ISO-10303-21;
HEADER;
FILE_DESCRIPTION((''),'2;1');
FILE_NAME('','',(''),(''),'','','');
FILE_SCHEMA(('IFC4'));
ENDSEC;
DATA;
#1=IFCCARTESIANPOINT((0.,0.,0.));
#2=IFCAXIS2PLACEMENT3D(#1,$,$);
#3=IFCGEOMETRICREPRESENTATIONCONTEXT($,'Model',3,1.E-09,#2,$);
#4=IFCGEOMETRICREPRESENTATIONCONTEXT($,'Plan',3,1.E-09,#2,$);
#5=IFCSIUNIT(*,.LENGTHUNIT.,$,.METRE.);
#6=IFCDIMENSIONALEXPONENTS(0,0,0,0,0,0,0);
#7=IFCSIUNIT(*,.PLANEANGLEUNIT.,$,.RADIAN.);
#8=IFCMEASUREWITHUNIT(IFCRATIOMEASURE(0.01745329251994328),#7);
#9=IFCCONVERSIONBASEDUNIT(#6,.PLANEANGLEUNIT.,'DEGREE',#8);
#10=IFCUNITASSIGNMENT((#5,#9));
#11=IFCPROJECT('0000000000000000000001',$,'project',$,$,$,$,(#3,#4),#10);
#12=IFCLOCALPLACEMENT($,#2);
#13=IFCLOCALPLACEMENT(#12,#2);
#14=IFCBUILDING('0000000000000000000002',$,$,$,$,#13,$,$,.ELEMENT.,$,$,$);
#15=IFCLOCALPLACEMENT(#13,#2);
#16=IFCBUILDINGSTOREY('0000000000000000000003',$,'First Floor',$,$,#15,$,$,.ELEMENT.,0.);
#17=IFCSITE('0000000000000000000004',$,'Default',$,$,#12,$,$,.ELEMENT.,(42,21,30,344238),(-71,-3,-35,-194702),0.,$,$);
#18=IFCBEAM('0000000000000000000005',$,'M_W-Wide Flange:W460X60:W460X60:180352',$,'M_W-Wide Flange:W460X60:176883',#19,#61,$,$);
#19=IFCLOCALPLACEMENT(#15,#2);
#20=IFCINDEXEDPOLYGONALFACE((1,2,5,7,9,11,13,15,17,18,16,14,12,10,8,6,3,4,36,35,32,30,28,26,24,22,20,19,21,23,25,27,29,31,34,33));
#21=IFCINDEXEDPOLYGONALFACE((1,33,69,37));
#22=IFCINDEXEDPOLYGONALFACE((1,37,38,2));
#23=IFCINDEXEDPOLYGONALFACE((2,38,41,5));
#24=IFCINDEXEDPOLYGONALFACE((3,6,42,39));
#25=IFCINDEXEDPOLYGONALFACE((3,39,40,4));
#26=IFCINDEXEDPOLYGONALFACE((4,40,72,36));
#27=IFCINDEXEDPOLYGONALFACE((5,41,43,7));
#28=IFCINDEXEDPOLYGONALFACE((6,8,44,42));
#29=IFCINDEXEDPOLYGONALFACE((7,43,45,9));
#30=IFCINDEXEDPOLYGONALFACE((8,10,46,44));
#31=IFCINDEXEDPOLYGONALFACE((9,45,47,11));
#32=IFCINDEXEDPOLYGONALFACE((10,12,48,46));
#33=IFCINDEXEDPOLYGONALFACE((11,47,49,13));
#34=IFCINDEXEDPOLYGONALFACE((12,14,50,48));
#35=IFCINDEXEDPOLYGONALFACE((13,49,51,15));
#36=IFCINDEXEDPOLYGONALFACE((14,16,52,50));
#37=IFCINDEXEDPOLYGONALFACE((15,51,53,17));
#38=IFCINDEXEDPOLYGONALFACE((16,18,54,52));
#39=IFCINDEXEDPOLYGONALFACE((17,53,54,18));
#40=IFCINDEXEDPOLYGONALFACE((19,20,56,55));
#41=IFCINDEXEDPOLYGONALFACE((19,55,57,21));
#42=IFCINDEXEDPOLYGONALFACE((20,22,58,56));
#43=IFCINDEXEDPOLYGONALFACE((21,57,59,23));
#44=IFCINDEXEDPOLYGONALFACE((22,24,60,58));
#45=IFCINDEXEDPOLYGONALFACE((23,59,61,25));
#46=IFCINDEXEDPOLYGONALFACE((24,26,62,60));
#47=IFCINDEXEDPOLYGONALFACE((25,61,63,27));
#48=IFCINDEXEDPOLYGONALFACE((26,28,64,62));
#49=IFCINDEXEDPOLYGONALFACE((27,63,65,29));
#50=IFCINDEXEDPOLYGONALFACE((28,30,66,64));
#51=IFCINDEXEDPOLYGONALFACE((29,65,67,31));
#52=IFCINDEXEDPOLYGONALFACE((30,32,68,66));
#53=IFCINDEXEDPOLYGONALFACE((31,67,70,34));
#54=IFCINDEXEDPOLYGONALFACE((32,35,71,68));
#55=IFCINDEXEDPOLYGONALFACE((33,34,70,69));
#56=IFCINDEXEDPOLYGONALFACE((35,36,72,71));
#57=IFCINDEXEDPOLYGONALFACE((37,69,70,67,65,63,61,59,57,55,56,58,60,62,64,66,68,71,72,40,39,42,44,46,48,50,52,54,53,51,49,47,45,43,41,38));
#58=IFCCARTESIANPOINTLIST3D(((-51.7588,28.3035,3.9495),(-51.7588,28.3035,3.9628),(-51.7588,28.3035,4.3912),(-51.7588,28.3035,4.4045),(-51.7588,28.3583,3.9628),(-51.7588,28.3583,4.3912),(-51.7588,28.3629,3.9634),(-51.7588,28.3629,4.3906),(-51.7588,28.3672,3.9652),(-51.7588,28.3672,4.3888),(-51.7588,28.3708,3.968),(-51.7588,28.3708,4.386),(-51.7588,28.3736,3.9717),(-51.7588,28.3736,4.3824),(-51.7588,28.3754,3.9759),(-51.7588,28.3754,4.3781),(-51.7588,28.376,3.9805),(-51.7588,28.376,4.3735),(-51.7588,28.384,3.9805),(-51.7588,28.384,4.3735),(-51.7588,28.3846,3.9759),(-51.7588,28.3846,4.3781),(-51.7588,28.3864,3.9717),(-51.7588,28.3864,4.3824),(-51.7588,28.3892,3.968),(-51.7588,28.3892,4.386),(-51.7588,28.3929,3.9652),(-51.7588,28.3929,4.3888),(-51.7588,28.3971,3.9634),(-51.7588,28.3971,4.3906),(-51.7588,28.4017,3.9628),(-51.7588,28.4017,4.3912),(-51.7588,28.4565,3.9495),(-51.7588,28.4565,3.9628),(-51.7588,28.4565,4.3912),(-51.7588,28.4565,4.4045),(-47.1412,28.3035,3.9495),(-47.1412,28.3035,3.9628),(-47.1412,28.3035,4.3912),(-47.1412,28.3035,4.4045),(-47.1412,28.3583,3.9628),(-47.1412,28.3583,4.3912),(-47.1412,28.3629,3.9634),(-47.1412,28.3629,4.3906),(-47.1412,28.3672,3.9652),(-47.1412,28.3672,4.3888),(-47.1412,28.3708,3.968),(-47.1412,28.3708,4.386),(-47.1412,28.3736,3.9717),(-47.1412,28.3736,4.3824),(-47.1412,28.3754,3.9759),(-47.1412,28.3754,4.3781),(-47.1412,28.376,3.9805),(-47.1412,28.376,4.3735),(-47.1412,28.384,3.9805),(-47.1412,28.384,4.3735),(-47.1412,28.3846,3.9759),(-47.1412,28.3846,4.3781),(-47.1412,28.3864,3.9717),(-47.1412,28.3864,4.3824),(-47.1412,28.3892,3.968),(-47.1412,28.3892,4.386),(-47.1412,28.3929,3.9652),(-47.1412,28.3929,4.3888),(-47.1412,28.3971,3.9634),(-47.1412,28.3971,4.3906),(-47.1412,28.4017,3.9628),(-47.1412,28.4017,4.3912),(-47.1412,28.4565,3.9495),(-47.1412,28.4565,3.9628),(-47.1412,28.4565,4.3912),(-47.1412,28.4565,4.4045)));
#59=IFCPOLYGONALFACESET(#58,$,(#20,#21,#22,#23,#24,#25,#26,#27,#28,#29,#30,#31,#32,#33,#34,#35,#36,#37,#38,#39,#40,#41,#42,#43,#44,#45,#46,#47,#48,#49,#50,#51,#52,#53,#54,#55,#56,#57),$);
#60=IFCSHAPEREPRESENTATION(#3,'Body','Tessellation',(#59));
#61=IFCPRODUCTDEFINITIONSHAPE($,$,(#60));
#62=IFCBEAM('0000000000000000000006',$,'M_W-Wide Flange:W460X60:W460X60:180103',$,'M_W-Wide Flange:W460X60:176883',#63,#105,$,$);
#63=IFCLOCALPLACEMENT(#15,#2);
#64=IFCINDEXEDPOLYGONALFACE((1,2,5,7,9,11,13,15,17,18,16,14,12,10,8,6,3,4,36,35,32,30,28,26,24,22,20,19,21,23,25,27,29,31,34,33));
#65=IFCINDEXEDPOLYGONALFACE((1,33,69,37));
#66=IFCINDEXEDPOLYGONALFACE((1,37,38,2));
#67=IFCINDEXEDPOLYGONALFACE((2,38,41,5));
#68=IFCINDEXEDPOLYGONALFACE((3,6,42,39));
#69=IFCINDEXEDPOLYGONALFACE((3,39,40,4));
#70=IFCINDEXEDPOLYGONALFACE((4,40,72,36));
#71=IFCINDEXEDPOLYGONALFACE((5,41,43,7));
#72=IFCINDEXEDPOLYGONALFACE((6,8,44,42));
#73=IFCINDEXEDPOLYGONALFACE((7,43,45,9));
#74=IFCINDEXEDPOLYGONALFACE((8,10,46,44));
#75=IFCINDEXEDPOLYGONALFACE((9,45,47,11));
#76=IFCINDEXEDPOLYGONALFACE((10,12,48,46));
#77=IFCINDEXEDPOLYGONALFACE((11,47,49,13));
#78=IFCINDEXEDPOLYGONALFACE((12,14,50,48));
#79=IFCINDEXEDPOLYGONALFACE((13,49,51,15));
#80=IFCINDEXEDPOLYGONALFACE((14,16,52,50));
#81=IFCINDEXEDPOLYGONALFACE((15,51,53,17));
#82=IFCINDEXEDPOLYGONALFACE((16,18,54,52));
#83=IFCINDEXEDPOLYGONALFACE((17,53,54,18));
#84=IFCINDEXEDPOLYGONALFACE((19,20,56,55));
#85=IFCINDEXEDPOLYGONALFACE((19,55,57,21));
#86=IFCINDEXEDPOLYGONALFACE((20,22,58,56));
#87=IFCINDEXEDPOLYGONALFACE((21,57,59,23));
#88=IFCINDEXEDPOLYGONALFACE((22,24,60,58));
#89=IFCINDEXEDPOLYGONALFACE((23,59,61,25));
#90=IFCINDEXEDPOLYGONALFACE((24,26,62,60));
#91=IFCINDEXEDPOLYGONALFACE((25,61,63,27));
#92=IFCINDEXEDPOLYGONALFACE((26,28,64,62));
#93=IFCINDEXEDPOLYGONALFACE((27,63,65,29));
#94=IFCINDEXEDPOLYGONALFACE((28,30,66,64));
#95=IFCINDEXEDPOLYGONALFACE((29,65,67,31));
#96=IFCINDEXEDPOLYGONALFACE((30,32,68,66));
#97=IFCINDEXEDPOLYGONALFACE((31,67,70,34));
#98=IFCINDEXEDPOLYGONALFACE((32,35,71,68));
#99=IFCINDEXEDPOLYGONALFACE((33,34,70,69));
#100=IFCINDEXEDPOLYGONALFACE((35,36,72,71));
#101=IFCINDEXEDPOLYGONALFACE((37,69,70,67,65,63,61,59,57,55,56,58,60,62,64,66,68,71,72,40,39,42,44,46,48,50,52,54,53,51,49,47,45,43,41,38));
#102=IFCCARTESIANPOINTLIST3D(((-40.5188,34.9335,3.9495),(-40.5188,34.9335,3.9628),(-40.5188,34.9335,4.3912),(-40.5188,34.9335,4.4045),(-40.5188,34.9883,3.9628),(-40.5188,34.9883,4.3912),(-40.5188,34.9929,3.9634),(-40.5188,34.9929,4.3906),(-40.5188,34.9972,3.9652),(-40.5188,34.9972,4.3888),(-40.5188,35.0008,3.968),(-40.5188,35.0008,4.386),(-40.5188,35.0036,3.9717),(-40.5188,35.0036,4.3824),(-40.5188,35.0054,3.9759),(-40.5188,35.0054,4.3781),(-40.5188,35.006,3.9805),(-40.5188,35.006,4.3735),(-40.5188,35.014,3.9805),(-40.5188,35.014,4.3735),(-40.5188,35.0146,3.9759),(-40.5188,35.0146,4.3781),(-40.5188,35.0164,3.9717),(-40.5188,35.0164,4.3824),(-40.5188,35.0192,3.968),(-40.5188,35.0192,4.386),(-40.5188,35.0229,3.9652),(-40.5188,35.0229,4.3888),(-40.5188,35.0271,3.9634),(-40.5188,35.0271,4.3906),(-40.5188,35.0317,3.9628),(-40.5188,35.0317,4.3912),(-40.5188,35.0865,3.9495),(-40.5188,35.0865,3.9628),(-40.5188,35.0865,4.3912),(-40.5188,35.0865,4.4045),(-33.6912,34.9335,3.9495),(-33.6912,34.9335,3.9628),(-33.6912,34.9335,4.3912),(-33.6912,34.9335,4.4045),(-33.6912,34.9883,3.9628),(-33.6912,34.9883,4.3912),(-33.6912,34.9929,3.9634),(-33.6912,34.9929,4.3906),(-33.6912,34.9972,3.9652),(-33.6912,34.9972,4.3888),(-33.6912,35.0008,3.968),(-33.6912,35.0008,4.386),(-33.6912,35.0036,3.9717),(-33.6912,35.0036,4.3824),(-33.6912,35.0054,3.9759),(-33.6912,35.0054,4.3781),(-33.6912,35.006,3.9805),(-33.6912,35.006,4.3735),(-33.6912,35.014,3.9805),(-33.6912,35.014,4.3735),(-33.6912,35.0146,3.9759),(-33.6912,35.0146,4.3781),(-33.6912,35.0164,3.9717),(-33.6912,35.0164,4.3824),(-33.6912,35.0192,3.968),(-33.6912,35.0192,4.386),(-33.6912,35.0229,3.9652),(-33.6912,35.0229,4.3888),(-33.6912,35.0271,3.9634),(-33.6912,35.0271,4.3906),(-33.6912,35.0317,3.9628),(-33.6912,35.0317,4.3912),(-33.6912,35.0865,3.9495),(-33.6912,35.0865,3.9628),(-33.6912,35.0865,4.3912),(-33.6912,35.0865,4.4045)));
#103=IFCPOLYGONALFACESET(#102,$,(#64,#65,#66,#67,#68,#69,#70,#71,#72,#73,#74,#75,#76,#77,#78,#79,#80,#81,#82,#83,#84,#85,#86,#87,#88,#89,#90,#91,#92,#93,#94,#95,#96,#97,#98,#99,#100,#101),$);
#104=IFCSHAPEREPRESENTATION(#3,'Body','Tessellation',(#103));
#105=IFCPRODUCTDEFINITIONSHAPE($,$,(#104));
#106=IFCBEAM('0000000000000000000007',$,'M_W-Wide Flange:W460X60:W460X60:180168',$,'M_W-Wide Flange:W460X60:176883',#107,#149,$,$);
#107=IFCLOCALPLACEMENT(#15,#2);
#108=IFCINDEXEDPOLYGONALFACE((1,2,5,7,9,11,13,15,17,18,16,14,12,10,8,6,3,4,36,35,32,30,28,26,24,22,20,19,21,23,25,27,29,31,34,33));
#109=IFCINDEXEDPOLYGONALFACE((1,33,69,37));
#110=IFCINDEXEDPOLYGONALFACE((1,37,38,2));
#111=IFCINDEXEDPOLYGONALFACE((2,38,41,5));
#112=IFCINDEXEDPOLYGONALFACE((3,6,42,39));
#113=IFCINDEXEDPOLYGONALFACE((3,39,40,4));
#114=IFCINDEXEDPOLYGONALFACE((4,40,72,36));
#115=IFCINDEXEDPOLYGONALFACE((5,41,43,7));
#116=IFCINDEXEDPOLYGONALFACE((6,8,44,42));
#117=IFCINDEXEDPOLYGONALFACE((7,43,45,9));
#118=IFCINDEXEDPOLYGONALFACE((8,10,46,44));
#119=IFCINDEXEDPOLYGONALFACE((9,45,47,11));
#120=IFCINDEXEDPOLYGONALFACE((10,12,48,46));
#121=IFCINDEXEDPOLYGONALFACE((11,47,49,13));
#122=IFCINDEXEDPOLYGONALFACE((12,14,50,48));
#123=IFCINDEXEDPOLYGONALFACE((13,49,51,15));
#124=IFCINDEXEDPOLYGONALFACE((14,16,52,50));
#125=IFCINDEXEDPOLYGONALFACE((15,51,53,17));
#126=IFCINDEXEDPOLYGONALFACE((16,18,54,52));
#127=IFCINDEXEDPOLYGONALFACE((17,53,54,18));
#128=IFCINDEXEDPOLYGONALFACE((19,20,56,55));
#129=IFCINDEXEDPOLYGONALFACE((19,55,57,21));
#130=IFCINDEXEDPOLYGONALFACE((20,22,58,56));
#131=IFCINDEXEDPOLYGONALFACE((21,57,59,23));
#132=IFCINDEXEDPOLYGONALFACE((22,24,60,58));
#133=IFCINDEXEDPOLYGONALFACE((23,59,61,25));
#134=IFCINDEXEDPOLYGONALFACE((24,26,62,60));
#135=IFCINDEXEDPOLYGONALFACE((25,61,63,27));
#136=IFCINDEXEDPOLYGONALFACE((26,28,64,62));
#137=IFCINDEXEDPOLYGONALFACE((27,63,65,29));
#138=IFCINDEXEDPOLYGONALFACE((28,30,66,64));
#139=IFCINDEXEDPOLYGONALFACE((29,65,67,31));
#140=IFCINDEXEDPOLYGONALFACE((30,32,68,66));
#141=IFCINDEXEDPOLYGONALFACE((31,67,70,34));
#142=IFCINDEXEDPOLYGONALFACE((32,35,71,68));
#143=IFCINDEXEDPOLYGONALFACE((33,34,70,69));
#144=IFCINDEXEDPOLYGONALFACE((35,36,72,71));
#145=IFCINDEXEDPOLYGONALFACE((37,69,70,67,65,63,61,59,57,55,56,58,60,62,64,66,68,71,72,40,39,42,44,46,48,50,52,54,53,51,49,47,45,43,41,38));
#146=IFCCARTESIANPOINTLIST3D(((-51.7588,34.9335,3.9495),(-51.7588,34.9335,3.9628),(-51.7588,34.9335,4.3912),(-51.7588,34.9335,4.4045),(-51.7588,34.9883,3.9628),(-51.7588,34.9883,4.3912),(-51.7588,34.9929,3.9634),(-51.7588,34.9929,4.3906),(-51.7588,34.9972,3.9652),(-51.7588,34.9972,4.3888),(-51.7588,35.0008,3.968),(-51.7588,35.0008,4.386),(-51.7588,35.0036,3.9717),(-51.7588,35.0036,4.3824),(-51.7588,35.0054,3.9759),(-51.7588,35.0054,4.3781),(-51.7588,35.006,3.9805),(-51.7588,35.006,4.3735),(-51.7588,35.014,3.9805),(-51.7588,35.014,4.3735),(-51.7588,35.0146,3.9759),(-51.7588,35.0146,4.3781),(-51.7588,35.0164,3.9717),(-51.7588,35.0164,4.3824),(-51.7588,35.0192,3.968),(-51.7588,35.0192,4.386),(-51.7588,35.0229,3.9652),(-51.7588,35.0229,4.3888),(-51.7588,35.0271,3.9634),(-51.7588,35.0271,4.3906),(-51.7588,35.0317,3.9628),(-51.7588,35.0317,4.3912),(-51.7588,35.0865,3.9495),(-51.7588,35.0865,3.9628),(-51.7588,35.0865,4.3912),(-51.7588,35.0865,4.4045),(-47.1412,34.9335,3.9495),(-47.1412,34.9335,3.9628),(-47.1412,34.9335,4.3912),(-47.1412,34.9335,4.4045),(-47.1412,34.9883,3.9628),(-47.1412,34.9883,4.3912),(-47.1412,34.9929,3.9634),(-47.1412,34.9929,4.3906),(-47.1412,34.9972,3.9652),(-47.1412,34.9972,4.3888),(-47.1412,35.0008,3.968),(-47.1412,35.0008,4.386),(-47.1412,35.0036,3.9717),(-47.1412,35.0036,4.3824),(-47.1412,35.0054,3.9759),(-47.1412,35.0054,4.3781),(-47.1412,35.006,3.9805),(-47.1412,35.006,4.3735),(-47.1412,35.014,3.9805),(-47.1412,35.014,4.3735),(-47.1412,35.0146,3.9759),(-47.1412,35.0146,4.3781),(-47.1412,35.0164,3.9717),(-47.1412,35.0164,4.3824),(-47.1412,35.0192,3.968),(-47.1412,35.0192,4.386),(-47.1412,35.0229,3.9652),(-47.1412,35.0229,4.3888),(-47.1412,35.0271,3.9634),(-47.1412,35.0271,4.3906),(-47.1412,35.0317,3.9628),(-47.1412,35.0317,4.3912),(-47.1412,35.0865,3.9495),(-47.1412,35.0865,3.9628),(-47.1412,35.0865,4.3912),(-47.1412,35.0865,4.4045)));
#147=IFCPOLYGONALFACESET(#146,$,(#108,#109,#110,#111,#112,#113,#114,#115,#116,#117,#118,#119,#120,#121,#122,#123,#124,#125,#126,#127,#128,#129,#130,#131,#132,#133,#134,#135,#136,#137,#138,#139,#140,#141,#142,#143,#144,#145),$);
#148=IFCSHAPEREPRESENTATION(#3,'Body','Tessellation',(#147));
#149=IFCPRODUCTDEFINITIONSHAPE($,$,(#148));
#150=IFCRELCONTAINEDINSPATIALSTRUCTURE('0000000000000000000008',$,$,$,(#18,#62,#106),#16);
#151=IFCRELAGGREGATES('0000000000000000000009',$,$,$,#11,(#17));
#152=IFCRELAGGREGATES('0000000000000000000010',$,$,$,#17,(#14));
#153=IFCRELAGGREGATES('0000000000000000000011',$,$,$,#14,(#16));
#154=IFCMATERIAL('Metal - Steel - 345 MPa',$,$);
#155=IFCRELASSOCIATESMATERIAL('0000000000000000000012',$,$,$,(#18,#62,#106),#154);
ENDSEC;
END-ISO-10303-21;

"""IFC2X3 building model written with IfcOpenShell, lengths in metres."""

from ifc_helpers import new_model, entity, si_unit, converted_unit, frame, frame_2d, origin, place, context, project, spatial, polyline, circle_curve, parameter, trimmed, segment, composite_curve, outline, extrude, material, element, save


model = new_model("IFC2X3")

# Units and contexts
model_context = context("Model", 3, precision=1e-09, world=origin())
plan_context = context("Plan", 3, precision=1e-09, world=origin())
ifc_project = project(units=[si_unit("LENGTHUNIT", "METRE"), converted_unit("PLANEANGLEUNIT", "DEGREE", entity("IfcRatioMeasure", 0.01745329251994328), si_unit("PLANEANGLEUNIT", "RADIAN"), dimensions=[0, 0, 0, 0, 0, 0, 0])], contexts=[model_context, plan_context])

# Site, building, storey
site_placement = place(None, origin())
site = spatial("IfcSite", under=ifc_project, at=site_placement, Name="Default", CompositionType="ELEMENT", RefLatitude=(42, 21, 30, 344238), RefLongitude=(-71, -3, -35, -194702), RefElevation=0.0)
building_placement = place(site_placement, origin())
building = spatial("IfcBuilding", under=site, at=building_placement, CompositionType="ELEMENT")
storey_placement = place(building_placement, origin())
storey = spatial("IfcBuildingStorey", under=building, at=storey_placement, Name="First Floor", CompositionType="ELEMENT", Elevation=0.0)

# Beams
ifc_material = material(Name="Metal - Steel - 345 MPa")
beam_1_placement = place(storey_placement, frame((-46.9972, 28.38, 4.4045), z_axis=(0.0, 0.0, 1.0), x_axis=(0.0, 1.0, 0.0)))
element("IfcBeam", 1, at=beam_1_placement, inside=storey, material=ifc_material, Name="M_W-Wide Flange:W460X60:W460X60:180352", ObjectType="M_W-Wide Flange:W460X60:176883", context=model_context, shape_type="SweptSolid", body=[
    extrude(outline(composite_curve([segment(polyline([(0.2142, -0.0765), (0.2275, -0.0765)]), True, "CONTINUOUS"), segment(polyline([(0.2275, -0.0765), (0.2275, 0.0765)]), True, "CONTINUOUS"), segment(polyline([(0.2275, 0.0765), (0.2142, 0.0765)]), True, "CONTINUOUS"), segment(polyline([(0.2142, 0.0765), (0.2142, 0.0217)]), True, "CONTINUOUS"), segment(trimmed(circle_curve(frame_2d((0.1965, 0.0217), x_axis=(0.0, 1.0)), 0.0177), [parameter(180.0)], [parameter(270.0)], True, "PARAMETER"), False, "CONTINUOUS"), segment(polyline([(0.1965, 0.004), (-0.1965, 0.004)]), True, "CONTINUOUS"), segment(trimmed(circle_curve(frame_2d((-0.1965, 0.0217), x_axis=(0.0, 1.0)), 0.0177), [parameter(90.0)], [parameter(180.0)], True, "PARAMETER"), False, "CONTINUOUS"), segment(polyline([(-0.2142, 0.0217), (-0.2142, 0.0765)]), True, "CONTINUOUS"), segment(polyline([(-0.2142, 0.0765), (-0.2275, 0.0765)]), True, "CONTINUOUS"), segment(polyline([(-0.2275, 0.0765), (-0.2275, -0.0765)]), True, "CONTINUOUS"), segment(polyline([(-0.2275, -0.0765), (-0.2142, -0.0765)]), True, "CONTINUOUS"), segment(polyline([(-0.2142, -0.0765), (-0.2142, -0.0217)]), True, "CONTINUOUS"), segment(trimmed(circle_curve(frame_2d((-0.1965, -0.0217), x_axis=(0.0, 1.0)), 0.0177), [parameter(360.0)], [parameter(90.0)], True, "PARAMETER"), False, "CONTINUOUS"), segment(polyline([(-0.1965, -0.004), (0.1965, -0.004)]), True, "CONTINUOUS"), segment(trimmed(circle_curve(frame_2d((0.1965, -0.0217), x_axis=(0.0, 1.0)), 0.0177), [parameter(270.0)], [parameter(0.0)], True, "PARAMETER"), False, "CONTINUOUS"), segment(polyline([(0.2142, -0.0217), (0.2142, -0.0765)]), True, "CONTINUOUS")], self_intersect=False)), frame((0.0, 4.7616, -0.2275), z_axis=(0.0, -1.0, 0.0), x_axis=(0.0, 0.0, -1.0)), (0.0, 0.0, 1.0), 4.6176),
])
beam_2_placement = place(storey_placement, frame((-33.5481, 35.01, 4.4045), z_axis=(0.0, 0.0, 1.0), x_axis=(0.0, 1.0, 0.0)))
element("IfcBeam", 2, at=beam_2_placement, inside=storey, material=ifc_material, Name="M_W-Wide Flange:W460X60:W460X60:180103", ObjectType="M_W-Wide Flange:W460X60:176883", context=model_context, shape_type="SweptSolid", body=[
    extrude(outline(composite_curve([segment(polyline([(0.2142, -0.0765), (0.2275, -0.0765)]), True, "CONTINUOUS"), segment(polyline([(0.2275, -0.0765), (0.2275, 0.0765)]), True, "CONTINUOUS"), segment(polyline([(0.2275, 0.0765), (0.2142, 0.0765)]), True, "CONTINUOUS"), segment(polyline([(0.2142, 0.0765), (0.2142, 0.0217)]), True, "CONTINUOUS"), segment(trimmed(circle_curve(frame_2d((0.1965, 0.0217), x_axis=(1.0, 0.0)), 0.0177), [parameter(270.0)], [parameter(360.0)], True, "PARAMETER"), False, "CONTINUOUS"), segment(polyline([(0.1965, 0.004), (-0.1965, 0.004)]), True, "CONTINUOUS"), segment(trimmed(circle_curve(frame_2d((-0.1965, 0.0217), x_axis=(0.0, -1.0)), 0.0177), [parameter(270.0)], [parameter(360.0)], True, "PARAMETER"), False, "CONTINUOUS"), segment(polyline([(-0.2142, 0.0217), (-0.2142, 0.0765)]), True, "CONTINUOUS"), segment(polyline([(-0.2142, 0.0765), (-0.2275, 0.0765)]), True, "CONTINUOUS"), segment(polyline([(-0.2275, 0.0765), (-0.2275, -0.0765)]), True, "CONTINUOUS"), segment(polyline([(-0.2275, -0.0765), (-0.2142, -0.0765)]), True, "CONTINUOUS"), segment(polyline([(-0.2142, -0.0765), (-0.2142, -0.0217)]), True, "CONTINUOUS"), segment(trimmed(circle_curve(frame_2d((-0.1965, -0.0217), x_axis=(-1.0, 0.0)), 0.0177), [parameter(270.0)], [parameter(360.0)], True, "PARAMETER"), False, "CONTINUOUS"), segment(polyline([(-0.1965, -0.004), (0.1965, -0.004)]), True, "CONTINUOUS"), segment(trimmed(circle_curve(frame_2d((0.1965, -0.0217), x_axis=(0.0, 1.0)), 0.0177), [parameter(270.0)], [parameter(0.0)], True, "PARAMETER"), False, "CONTINUOUS"), segment(polyline([(0.2142, -0.0217), (0.2142, -0.0765)]), True, "CONTINUOUS")], self_intersect=False)), frame((0.0, 6.9707, -0.2275), z_axis=(0.0, -1.0, 0.0), x_axis=(0.0, 0.0, -1.0)), (0.0, 0.0, 1.0), 6.8276),
])
beam_3_placement = place(storey_placement, frame((-46.9972, 35.01, 4.4045), z_axis=(0.0, 0.0, 1.0), x_axis=(0.0, 1.0, 0.0)))
element("IfcBeam", 3, at=beam_3_placement, inside=storey, material=ifc_material, Name="M_W-Wide Flange:W460X60:W460X60:180168", ObjectType="M_W-Wide Flange:W460X60:176883", context=model_context, shape_type="SweptSolid", body=[
    extrude(outline(composite_curve([segment(polyline([(0.2142, -0.0765), (0.2275, -0.0765)]), True, "CONTINUOUS"), segment(polyline([(0.2275, -0.0765), (0.2275, 0.0765)]), True, "CONTINUOUS"), segment(polyline([(0.2275, 0.0765), (0.2142, 0.0765)]), True, "CONTINUOUS"), segment(polyline([(0.2142, 0.0765), (0.2142, 0.0217)]), True, "CONTINUOUS"), segment(trimmed(circle_curve(frame_2d((0.1965, 0.0217), x_axis=(0.0, 1.0)), 0.0177), [parameter(180.0)], [parameter(270.0)], True, "PARAMETER"), False, "CONTINUOUS"), segment(polyline([(0.1965, 0.004), (-0.1965, 0.004)]), True, "CONTINUOUS"), segment(trimmed(circle_curve(frame_2d((-0.1965, 0.0217), x_axis=(0.0, 1.0)), 0.0177), [parameter(90.0)], [parameter(180.0)], True, "PARAMETER"), False, "CONTINUOUS"), segment(polyline([(-0.2142, 0.0217), (-0.2142, 0.0765)]), True, "CONTINUOUS"), segment(polyline([(-0.2142, 0.0765), (-0.2275, 0.0765)]), True, "CONTINUOUS"), segment(polyline([(-0.2275, 0.0765), (-0.2275, -0.0765)]), True, "CONTINUOUS"), segment(polyline([(-0.2275, -0.0765), (-0.2142, -0.0765)]), True, "CONTINUOUS"), segment(polyline([(-0.2142, -0.0765), (-0.2142, -0.0217)]), True, "CONTINUOUS"), segment(trimmed(circle_curve(frame_2d((-0.1965, -0.0217), x_axis=(0.0, 1.0)), 0.0177), [parameter(360.0)], [parameter(90.0)], True, "PARAMETER"), False, "CONTINUOUS"), segment(polyline([(-0.1965, -0.004), (0.1965, -0.004)]), True, "CONTINUOUS"), segment(trimmed(circle_curve(frame_2d((0.1965, -0.0217), x_axis=(0.0, 1.0)), 0.0177), [parameter(270.0)], [parameter(0.0)], True, "PARAMETER"), False, "CONTINUOUS"), segment(polyline([(0.2142, -0.0217), (0.2142, -0.0765)]), True, "CONTINUOUS")], self_intersect=False)), frame((0.0, 4.7616, -0.2275), z_axis=(0.0, -1.0, 0.0), x_axis=(0.0, 0.0, -1.0)), (0.0, 0.0, 1.0), 4.6176),
])

save(model, "model.ifc")
